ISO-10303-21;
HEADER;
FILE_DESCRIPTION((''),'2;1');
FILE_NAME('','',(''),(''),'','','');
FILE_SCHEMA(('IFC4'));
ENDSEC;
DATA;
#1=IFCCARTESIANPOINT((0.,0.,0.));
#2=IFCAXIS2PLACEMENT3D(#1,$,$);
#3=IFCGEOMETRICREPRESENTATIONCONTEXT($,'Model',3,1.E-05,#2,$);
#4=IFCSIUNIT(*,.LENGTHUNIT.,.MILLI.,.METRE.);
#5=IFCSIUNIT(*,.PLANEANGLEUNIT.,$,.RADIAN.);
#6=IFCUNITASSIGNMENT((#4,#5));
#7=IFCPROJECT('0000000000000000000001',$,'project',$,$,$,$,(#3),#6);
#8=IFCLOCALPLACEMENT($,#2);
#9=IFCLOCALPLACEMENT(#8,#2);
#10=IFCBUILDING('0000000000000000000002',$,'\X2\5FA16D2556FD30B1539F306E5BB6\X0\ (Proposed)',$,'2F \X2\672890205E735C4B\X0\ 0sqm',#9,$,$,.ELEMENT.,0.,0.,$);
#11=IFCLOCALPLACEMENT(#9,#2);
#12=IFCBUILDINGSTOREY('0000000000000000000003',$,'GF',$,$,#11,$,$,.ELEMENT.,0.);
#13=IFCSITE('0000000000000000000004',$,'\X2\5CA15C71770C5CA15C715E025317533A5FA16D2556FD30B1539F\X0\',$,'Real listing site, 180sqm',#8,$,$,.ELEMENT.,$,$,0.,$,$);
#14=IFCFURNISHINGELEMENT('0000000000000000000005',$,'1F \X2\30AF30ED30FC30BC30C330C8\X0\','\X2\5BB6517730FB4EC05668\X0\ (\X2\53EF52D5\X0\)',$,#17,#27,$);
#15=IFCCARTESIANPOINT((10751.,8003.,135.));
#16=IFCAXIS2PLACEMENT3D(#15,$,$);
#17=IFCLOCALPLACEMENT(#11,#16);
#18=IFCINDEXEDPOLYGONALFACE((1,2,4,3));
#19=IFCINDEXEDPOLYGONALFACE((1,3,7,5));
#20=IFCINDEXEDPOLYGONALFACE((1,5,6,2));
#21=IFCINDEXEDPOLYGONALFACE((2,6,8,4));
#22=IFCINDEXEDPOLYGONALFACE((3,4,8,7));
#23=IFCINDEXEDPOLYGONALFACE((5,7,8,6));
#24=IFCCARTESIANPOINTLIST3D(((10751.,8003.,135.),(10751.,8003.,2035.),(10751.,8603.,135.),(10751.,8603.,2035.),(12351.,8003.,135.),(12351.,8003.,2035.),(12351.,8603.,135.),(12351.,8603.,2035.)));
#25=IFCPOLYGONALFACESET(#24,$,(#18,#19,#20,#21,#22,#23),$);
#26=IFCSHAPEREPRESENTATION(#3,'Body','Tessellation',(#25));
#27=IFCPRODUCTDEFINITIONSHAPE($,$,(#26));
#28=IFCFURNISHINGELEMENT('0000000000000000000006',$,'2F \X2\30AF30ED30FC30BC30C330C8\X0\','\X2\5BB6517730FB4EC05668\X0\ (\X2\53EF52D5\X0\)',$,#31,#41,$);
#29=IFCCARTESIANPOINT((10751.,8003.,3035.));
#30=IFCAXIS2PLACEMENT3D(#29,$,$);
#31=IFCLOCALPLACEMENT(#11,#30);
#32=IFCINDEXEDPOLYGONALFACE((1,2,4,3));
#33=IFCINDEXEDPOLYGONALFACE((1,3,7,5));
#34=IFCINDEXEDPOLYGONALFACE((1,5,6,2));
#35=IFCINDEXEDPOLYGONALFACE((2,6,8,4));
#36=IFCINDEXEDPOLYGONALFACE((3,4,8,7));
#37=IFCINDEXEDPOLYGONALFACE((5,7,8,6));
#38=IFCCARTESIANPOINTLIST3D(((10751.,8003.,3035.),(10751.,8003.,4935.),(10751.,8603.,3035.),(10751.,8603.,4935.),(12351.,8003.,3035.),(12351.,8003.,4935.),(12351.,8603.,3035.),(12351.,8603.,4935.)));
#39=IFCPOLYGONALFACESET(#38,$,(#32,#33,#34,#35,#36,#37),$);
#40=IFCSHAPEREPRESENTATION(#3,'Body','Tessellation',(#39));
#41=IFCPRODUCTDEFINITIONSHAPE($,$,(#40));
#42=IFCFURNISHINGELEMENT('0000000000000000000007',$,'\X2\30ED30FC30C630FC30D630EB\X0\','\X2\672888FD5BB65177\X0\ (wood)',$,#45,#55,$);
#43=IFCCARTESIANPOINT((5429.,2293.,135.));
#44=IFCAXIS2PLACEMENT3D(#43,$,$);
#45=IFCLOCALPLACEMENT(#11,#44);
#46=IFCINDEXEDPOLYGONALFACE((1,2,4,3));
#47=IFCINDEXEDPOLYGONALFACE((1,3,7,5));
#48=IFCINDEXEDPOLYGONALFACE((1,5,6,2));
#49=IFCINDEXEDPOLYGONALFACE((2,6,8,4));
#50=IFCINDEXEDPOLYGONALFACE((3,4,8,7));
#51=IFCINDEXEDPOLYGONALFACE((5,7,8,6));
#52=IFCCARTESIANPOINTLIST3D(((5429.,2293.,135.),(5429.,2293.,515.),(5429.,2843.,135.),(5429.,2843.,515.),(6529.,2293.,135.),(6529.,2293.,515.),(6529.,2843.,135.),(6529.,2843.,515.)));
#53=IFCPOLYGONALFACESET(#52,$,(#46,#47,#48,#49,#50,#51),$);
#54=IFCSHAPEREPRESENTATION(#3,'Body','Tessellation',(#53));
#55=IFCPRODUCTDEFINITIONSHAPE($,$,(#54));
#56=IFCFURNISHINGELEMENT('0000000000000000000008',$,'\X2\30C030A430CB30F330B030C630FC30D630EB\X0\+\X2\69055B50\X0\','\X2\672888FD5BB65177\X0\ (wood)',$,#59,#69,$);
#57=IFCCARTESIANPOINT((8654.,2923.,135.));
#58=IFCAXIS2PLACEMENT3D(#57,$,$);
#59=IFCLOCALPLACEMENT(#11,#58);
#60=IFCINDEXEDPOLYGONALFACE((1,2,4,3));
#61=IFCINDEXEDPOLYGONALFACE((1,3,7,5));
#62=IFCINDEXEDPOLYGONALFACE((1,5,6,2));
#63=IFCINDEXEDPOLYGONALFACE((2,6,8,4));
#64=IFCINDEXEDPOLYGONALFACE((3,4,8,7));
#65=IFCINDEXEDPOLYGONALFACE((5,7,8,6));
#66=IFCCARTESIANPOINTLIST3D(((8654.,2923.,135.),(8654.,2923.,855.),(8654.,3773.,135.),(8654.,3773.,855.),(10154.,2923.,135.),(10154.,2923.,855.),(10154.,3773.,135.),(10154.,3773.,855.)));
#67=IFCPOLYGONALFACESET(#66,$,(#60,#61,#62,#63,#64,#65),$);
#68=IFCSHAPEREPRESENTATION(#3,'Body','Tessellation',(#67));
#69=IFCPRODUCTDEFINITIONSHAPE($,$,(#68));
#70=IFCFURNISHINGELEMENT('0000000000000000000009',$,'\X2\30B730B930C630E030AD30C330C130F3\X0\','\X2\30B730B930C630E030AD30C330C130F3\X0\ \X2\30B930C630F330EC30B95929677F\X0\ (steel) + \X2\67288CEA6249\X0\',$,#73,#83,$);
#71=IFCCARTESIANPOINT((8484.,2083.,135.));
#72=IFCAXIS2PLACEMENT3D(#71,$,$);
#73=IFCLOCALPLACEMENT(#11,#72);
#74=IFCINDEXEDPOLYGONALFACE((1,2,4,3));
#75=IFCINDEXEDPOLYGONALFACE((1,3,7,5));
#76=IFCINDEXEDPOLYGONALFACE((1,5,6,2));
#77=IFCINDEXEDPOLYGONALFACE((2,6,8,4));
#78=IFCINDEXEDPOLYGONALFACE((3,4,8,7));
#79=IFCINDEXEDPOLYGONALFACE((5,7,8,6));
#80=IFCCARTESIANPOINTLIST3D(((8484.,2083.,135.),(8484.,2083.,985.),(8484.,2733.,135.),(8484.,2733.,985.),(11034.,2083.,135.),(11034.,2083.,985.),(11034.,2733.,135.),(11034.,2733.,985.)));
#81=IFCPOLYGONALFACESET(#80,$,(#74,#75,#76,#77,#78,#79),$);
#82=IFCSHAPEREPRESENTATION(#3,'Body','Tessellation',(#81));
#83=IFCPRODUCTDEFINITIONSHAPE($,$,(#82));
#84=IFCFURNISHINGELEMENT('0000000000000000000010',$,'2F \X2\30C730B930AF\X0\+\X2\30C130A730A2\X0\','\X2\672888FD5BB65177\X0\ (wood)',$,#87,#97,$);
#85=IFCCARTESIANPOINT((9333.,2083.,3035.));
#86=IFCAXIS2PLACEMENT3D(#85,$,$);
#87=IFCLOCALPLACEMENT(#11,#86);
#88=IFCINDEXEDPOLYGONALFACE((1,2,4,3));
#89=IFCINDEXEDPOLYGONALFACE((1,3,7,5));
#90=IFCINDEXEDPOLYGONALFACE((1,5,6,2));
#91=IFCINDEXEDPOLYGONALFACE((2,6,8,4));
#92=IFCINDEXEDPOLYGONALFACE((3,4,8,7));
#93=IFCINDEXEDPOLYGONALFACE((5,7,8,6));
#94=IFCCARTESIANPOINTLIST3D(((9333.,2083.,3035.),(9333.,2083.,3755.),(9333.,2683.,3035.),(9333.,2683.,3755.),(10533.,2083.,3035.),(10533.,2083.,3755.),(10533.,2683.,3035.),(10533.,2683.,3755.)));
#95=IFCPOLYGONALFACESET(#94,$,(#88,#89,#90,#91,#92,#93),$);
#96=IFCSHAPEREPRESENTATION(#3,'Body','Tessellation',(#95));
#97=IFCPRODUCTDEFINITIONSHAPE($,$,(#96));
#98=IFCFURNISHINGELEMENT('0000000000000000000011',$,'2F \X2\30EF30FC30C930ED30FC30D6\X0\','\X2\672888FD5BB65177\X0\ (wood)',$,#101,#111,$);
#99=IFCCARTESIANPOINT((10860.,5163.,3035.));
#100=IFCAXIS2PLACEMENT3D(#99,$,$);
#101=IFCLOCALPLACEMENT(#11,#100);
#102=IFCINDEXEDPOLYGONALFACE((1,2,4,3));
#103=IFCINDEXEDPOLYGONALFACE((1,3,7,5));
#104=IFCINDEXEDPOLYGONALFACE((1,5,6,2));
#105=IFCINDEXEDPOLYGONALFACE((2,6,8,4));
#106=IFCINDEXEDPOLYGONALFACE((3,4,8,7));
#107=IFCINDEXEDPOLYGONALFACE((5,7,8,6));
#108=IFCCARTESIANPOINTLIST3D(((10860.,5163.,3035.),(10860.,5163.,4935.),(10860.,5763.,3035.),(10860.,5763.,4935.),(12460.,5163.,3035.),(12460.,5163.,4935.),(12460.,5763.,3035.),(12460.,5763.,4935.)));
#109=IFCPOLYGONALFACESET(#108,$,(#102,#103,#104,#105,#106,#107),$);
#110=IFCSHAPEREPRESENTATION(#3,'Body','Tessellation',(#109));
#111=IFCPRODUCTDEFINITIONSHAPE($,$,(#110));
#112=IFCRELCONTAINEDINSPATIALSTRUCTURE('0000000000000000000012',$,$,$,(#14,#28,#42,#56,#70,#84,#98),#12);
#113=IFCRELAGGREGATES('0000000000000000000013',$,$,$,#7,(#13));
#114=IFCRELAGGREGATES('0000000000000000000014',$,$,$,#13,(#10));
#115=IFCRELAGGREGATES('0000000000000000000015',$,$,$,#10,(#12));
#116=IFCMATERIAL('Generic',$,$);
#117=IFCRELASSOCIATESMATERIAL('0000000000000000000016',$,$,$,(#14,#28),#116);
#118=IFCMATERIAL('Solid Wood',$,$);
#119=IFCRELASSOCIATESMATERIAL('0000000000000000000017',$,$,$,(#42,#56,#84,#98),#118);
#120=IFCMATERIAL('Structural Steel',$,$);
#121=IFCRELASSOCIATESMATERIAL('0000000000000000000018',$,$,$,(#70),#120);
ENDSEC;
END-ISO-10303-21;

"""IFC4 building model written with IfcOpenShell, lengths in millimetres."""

from ifc_helpers import new_model, si_unit, frame, frame_2d, origin, place, context, project, spatial, rectangle, extrude, material, element, save


model = new_model("IFC4")

# Units and contexts
model_context = context("Model", 3, precision=1e-05, world=origin())
ifc_project = project(units=[si_unit("LENGTHUNIT", "METRE", prefix="MILLI"), si_unit("PLANEANGLEUNIT", "RADIAN")], contexts=[model_context])

# Site, building, storey
site_placement = place(None, origin())
site = spatial("IfcSite", under=ifc_project, at=site_placement, Name="岡山県岡山市北区御津国ケ原", ObjectType="Real listing site, 180sqm", CompositionType="ELEMENT", RefElevation=0.0)
building_placement = place(site_placement, origin())
building = spatial("IfcBuilding", under=site, at=building_placement, Name="御津国ケ原の家 (Proposed)", ObjectType="2F 木造平屋 0sqm", CompositionType="ELEMENT", ElevationOfRefHeight=0.0, ElevationOfTerrain=0.0)
storey_placement = place(building_placement, origin())
storey = spatial("IfcBuildingStorey", under=building, at=storey_placement, Name="GF", CompositionType="ELEMENT", Elevation=0.0)

# Shared definitions
ifc_material_1 = material(Name="Solid Wood")

# Shared definitions
ifc_material_2 = material(Name="Generic")

# Furnishing elements
furnishing_1_placement = place(storey_placement, frame((10751.0, 8003.0, 135.0)))
element("IfcFurnishingElement", 1, at=furnishing_1_placement, inside=storey, material=ifc_material_2, Name="1F クローゼット", Description="家具・什器 (可動)", context=model_context, shape_type="SweptSolid", body=[
    extrude(rectangle(XDim=1600.0, YDim=600.0, at=frame_2d((800.0, 300.0))), frame((10751.0, 8003.0, 135.0)), (0.0, 0.0, 1.0), 1900.0),
])
furnishing_2_placement = place(storey_placement, frame((10751.0, 8003.0, 3035.0)))
element("IfcFurnishingElement", 2, at=furnishing_2_placement, inside=storey, material=ifc_material_2, Name="2F クローゼット", Description="家具・什器 (可動)", context=model_context, shape_type="SweptSolid", body=[
    extrude(rectangle(XDim=1600.0, YDim=600.0, at=frame_2d((800.0, 300.0))), frame((10751.0, 8003.0, 3035.0)), (0.0, 0.0, 1.0), 1900.0),
])
furnishing_3_placement = place(storey_placement, frame((5429.0, 2293.0, 135.0)))
element("IfcFurnishingElement", 3, at=furnishing_3_placement, inside=storey, material=ifc_material_1, Name="ローテーブル", Description="木製家具 (wood)", context=model_context, shape_type="SweptSolid", body=[
    extrude(rectangle(XDim=1100.0, YDim=550.0, at=frame_2d((550.0, 275.0))), frame((5429.0, 2293.0, 135.0)), (0.0, 0.0, 1.0), 380.0),
])
furnishing_4_placement = place(storey_placement, frame((8654.0, 2923.0, 135.0)))
element("IfcFurnishingElement", 4, at=furnishing_4_placement, inside=storey, material=ifc_material_1, Name="ダイニングテーブル+椅子", Description="木製家具 (wood)", context=model_context, shape_type="SweptSolid", body=[
    extrude(rectangle(XDim=1500.0, YDim=850.0, at=frame_2d((750.0, 425.0))), frame((8654.0, 2923.0, 135.0)), (0.0, 0.0, 1.0), 720.0),
])
ifc_material_3 = material(Name="Structural Steel")
furnishing_5_placement = place(storey_placement, frame((8484.0, 2083.0, 135.0)))
element("IfcFurnishingElement", 5, at=furnishing_5_placement, inside=storey, material=ifc_material_3, Name="システムキッチン", Description="システムキッチン ステンレス天板 (steel) + 木質扉", context=model_context, shape_type="SweptSolid", body=[
    extrude(rectangle(XDim=2550.0, YDim=650.0, at=frame_2d((1275.0, 325.0))), frame((8484.0, 2083.0, 135.0)), (0.0, 0.0, 1.0), 850.0),
])
furnishing_6_placement = place(storey_placement, frame((9333.0, 2083.0, 3035.0)))
element("IfcFurnishingElement", 6, at=furnishing_6_placement, inside=storey, material=ifc_material_1, Name="2F デスク+チェア", Description="木製家具 (wood)", context=model_context, shape_type="SweptSolid", body=[
    extrude(rectangle(XDim=1200.0, YDim=600.0, at=frame_2d((600.0, 300.0))), frame((9333.0, 2083.0, 3035.0)), (0.0, 0.0, 1.0), 720.0),
])
furnishing_7_placement = place(storey_placement, frame((10860.0, 5163.0, 3035.0)))
element("IfcFurnishingElement", 7, at=furnishing_7_placement, inside=storey, material=ifc_material_1, Name="2F ワードローブ", Description="木製家具 (wood)", context=model_context, shape_type="SweptSolid", body=[
    extrude(rectangle(XDim=1600.0, YDim=600.0, at=frame_2d((800.0, 300.0))), frame((10860.0, 5163.0, 3035.0)), (0.0, 0.0, 1.0), 1900.0),
])

save(model, "model.ifc")
